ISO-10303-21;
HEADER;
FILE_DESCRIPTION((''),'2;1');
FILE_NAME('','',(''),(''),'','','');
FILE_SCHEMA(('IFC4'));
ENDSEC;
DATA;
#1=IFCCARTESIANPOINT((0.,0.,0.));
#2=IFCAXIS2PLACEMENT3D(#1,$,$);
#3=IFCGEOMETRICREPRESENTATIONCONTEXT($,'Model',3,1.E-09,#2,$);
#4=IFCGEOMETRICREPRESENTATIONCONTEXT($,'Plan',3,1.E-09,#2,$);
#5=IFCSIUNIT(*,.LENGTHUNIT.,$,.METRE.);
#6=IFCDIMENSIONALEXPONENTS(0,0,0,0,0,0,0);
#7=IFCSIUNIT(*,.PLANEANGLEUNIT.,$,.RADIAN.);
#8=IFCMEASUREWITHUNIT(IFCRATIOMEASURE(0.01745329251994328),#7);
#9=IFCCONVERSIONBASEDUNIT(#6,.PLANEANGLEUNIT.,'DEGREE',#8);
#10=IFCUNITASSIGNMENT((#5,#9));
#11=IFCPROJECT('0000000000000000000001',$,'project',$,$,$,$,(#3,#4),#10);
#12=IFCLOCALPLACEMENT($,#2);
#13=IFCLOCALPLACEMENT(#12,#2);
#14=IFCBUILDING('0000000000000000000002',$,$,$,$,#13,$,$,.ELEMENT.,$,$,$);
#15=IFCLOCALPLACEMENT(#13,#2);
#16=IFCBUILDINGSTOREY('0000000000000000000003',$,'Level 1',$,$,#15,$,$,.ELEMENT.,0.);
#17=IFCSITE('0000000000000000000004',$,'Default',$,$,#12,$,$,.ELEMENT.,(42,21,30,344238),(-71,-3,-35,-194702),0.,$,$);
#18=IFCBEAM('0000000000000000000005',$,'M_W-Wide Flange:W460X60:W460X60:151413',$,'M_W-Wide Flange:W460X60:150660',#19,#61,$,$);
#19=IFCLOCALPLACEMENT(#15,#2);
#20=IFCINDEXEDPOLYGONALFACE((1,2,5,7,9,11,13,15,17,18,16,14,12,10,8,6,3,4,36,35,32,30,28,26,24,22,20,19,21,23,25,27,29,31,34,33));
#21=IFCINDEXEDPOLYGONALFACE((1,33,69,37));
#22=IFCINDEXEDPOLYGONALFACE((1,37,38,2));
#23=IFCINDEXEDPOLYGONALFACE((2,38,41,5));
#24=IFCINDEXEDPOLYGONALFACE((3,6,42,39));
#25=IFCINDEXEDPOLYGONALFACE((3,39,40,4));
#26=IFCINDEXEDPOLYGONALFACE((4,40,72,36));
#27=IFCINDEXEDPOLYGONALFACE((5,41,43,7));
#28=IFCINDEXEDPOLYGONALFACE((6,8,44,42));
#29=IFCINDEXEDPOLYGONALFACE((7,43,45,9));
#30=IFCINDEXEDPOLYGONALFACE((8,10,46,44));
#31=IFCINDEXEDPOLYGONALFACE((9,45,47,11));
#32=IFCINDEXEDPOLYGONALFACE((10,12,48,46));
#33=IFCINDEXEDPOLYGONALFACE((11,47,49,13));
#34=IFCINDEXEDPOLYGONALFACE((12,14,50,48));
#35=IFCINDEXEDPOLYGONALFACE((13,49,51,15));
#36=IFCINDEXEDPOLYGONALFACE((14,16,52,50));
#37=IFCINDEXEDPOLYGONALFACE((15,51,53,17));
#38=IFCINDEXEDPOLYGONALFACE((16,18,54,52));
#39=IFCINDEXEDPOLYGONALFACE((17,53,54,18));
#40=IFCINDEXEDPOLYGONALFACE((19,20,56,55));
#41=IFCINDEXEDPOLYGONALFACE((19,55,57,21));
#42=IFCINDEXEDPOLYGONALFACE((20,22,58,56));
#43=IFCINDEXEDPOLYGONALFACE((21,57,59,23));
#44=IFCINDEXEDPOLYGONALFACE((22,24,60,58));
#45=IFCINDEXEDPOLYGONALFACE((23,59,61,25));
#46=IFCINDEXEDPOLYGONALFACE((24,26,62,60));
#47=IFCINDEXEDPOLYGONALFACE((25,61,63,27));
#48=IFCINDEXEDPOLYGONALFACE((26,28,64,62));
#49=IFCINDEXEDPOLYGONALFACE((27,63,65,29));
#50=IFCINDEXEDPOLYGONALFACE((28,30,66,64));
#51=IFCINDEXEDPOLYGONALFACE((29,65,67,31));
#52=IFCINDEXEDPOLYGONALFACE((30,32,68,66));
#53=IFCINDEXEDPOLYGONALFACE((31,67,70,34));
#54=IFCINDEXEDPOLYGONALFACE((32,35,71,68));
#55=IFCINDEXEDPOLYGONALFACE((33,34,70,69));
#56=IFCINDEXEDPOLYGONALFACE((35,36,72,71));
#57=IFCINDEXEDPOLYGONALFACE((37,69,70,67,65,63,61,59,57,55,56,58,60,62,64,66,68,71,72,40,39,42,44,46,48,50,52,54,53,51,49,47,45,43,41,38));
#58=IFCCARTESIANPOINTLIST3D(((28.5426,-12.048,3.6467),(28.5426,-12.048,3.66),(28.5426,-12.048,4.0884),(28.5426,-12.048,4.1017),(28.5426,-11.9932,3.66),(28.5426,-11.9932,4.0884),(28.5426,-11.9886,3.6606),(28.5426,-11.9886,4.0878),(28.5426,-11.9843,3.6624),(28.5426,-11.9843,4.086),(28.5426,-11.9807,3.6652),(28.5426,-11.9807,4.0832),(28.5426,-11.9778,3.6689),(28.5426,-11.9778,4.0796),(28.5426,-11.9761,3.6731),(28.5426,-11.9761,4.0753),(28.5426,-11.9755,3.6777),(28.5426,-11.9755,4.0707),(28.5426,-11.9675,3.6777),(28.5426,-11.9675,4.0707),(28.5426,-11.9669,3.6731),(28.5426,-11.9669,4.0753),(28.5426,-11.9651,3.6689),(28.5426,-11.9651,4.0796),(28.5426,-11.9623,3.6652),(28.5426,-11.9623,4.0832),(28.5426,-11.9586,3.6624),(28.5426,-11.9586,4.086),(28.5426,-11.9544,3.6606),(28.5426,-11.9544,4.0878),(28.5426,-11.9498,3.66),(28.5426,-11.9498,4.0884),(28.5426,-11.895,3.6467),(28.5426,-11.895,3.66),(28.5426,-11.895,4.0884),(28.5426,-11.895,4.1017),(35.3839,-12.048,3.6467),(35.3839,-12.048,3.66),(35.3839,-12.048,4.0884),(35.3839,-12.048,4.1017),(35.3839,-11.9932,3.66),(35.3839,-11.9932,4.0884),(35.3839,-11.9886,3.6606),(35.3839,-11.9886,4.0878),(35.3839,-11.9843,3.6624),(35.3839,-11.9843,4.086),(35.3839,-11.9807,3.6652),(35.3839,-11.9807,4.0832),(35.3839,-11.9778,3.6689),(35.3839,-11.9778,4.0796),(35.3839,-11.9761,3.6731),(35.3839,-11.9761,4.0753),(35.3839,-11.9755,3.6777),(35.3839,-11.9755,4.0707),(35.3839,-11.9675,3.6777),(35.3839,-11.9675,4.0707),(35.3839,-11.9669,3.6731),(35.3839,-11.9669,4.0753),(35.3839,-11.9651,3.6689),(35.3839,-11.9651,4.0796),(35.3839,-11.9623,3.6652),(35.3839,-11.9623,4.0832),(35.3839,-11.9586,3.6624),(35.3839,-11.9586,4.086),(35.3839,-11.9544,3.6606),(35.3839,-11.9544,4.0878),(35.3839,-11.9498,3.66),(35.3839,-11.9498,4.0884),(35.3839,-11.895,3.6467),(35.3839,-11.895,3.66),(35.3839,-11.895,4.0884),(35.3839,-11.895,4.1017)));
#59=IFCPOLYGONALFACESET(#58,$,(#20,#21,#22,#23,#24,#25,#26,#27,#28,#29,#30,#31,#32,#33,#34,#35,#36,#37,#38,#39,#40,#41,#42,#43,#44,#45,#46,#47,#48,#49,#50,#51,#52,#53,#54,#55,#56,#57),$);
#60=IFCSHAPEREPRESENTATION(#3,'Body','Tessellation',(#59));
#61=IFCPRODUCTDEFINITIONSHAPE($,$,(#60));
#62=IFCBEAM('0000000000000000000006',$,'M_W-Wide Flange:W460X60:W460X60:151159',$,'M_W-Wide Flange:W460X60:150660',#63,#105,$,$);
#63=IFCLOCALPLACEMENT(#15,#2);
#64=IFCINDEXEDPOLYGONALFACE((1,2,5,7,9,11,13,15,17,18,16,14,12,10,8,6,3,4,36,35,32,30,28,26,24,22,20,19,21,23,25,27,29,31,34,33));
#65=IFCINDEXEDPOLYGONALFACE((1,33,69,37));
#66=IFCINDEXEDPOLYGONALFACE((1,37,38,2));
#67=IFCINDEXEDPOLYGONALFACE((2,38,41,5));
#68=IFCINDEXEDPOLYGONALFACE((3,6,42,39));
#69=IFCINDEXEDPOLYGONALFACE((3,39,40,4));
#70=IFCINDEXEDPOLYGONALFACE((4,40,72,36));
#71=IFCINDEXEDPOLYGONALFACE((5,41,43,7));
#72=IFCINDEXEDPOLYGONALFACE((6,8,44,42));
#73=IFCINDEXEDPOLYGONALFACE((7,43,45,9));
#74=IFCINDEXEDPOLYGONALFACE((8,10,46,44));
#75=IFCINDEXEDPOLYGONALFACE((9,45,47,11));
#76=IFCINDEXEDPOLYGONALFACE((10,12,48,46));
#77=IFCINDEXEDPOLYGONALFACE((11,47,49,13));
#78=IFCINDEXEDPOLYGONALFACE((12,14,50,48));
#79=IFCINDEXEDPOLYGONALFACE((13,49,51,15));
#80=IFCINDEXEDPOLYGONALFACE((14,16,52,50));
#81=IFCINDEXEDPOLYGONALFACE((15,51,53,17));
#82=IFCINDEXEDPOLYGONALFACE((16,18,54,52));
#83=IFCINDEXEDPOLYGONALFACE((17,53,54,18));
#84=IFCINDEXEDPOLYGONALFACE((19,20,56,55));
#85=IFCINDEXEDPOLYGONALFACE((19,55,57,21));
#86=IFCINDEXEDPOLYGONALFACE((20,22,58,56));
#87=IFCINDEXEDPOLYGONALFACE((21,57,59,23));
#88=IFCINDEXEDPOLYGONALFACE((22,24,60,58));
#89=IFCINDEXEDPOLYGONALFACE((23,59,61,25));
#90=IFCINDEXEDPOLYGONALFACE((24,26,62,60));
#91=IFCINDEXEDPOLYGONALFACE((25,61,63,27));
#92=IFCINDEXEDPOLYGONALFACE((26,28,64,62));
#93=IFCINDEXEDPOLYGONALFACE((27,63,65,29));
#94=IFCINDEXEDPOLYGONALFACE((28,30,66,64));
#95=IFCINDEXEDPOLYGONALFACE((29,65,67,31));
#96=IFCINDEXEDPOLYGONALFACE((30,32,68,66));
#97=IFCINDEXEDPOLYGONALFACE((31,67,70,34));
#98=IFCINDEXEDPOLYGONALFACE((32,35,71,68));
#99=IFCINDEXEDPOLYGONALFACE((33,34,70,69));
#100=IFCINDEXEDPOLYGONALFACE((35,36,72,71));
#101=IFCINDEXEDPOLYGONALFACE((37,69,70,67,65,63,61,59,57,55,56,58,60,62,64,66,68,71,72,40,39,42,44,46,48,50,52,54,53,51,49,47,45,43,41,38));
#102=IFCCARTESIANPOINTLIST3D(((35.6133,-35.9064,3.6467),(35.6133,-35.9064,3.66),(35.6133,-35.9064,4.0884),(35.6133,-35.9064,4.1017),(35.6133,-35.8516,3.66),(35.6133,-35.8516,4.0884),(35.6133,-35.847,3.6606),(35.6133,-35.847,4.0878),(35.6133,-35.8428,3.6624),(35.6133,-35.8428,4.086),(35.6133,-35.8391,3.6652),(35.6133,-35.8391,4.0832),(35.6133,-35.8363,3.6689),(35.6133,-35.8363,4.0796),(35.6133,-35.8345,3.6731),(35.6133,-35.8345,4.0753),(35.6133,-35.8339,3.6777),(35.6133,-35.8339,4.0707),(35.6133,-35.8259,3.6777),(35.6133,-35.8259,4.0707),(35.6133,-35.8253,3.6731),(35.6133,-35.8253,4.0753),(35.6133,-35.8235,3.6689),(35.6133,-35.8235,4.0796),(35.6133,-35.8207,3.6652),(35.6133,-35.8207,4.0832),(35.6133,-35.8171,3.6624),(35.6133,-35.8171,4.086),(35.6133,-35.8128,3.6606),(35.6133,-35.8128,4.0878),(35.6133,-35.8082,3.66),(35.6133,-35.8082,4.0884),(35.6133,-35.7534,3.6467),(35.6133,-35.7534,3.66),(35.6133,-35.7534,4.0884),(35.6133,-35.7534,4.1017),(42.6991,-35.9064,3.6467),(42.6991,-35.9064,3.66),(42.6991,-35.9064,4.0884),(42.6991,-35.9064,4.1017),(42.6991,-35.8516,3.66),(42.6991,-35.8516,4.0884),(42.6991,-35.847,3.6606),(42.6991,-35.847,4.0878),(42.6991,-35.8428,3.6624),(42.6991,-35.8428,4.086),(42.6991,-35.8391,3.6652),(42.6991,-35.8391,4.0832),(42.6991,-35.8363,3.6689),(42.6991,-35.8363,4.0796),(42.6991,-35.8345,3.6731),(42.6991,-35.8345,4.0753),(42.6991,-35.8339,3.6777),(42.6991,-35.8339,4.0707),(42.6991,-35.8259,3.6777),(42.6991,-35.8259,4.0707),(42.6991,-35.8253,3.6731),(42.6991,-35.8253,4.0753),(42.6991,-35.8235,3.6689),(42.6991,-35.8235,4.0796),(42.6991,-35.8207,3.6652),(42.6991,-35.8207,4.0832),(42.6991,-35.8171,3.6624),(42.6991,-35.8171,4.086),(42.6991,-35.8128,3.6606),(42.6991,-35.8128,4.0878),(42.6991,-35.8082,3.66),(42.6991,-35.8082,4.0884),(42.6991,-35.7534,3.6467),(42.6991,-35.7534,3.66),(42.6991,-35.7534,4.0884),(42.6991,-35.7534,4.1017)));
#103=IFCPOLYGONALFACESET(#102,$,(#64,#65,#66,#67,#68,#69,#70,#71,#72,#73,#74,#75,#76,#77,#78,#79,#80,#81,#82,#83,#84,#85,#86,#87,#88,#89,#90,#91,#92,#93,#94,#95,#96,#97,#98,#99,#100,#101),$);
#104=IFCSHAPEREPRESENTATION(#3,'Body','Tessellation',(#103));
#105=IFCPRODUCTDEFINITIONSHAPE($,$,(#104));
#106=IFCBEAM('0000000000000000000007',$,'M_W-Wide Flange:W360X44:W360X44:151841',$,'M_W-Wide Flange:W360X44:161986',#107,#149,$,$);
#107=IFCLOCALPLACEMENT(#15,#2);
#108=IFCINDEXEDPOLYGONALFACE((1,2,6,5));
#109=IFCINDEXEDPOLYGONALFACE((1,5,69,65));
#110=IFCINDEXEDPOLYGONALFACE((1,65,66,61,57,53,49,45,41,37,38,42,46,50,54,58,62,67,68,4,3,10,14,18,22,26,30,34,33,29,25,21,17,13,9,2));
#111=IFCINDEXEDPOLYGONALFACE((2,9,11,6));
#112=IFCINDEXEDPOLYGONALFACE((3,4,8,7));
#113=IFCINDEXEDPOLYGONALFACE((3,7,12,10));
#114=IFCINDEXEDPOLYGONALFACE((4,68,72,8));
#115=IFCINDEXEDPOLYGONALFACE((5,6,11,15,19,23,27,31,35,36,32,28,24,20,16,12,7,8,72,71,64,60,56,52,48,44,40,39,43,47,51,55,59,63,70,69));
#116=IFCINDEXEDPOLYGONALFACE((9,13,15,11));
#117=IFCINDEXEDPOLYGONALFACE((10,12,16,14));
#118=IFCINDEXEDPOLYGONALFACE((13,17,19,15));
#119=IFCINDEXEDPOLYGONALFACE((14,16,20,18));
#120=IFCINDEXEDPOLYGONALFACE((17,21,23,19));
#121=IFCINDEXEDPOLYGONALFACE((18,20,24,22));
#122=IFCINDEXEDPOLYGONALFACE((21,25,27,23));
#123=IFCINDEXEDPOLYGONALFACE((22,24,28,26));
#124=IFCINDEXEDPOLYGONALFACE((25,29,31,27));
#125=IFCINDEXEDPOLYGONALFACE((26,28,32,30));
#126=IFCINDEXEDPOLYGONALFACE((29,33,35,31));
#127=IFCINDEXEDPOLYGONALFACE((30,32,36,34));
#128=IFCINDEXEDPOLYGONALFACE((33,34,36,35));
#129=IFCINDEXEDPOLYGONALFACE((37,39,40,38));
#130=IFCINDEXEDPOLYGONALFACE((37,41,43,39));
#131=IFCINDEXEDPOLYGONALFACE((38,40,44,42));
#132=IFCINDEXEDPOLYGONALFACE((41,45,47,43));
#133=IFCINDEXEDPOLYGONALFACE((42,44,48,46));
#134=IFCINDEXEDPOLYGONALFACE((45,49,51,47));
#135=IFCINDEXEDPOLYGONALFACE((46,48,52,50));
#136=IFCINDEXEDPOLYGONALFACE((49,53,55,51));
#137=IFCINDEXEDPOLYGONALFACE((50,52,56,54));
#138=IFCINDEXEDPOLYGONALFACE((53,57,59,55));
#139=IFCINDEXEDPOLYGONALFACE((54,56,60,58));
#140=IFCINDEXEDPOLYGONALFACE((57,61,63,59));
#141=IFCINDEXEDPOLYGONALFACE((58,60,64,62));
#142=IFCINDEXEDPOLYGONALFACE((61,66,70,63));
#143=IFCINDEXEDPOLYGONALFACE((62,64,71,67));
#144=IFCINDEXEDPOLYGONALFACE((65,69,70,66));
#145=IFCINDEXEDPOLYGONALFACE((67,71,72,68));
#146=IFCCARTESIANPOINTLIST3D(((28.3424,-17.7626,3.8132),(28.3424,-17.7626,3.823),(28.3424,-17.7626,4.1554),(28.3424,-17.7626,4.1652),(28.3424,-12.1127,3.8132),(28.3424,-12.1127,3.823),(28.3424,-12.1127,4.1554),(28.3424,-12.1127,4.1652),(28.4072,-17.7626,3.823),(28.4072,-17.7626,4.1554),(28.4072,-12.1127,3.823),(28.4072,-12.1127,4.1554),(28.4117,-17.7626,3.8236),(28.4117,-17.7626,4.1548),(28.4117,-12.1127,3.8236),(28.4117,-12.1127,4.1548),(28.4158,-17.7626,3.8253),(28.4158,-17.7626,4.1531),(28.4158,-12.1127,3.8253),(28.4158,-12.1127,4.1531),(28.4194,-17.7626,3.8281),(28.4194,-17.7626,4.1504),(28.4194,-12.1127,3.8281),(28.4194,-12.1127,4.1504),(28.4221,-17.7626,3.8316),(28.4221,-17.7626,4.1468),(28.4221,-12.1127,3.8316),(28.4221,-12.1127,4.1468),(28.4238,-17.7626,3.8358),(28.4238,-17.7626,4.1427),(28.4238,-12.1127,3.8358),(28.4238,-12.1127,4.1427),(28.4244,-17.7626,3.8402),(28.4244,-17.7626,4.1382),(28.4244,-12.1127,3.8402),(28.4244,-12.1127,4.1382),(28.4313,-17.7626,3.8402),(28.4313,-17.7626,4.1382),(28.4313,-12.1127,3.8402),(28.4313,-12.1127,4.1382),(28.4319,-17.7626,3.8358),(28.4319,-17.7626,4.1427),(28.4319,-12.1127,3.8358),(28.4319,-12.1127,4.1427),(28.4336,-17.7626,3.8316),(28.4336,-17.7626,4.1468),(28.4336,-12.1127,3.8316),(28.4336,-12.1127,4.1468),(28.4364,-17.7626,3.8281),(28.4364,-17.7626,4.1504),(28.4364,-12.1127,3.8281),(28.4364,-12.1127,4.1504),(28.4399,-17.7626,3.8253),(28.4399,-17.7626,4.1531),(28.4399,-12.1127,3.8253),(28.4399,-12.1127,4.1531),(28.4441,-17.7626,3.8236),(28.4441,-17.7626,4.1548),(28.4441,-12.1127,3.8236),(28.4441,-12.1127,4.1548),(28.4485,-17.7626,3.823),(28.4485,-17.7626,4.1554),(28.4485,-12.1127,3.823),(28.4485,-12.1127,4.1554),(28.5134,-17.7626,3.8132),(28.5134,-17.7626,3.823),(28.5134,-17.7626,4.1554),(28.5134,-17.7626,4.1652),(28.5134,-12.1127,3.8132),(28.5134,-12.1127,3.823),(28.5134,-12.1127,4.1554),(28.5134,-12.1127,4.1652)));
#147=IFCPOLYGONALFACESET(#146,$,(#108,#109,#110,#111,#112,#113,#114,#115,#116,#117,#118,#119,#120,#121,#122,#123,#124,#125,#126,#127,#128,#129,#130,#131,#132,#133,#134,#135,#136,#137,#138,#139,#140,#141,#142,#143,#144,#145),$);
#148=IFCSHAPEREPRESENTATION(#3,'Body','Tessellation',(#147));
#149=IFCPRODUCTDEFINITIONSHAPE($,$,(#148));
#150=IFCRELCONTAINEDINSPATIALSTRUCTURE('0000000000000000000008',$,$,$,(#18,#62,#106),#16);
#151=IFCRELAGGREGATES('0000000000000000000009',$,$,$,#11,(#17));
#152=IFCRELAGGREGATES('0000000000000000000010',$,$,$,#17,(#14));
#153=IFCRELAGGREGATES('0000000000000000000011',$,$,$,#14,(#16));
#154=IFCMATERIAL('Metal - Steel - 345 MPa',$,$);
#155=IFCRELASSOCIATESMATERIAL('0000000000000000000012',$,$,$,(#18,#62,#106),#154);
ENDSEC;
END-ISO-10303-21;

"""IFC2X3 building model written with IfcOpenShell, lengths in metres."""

from ifc_helpers import new_model, entity, si_unit, converted_unit, frame, frame_2d, origin, place, context, project, spatial, polyline, circle_curve, parameter, trimmed, segment, composite_curve, outline, extrude, material, element, save


model = new_model("IFC2X3")

# Units and contexts
model_context = context("Model", 3, precision=1e-09, world=origin())
plan_context = context("Plan", 3, precision=1e-09, world=origin())
ifc_project = project(units=[si_unit("LENGTHUNIT", "METRE"), converted_unit("PLANEANGLEUNIT", "DEGREE", entity("IfcRatioMeasure", 0.01745329251994328), si_unit("PLANEANGLEUNIT", "RADIAN"), dimensions=[0, 0, 0, 0, 0, 0, 0])], contexts=[model_context, plan_context])

# Site, building, storey
site_placement = place(None, origin())
site = spatial("IfcSite", under=ifc_project, at=site_placement, Name="Default", CompositionType="ELEMENT", RefLatitude=(42, 21, 30, 344238), RefLongitude=(-71, -3, -35, -194702), RefElevation=0.0)
building_placement = place(site_placement, origin())
building = spatial("IfcBuilding", under=site, at=building_placement, CompositionType="ELEMENT")
storey_placement = place(building_placement, origin())
storey = spatial("IfcBuildingStorey", under=building, at=storey_placement, Name="Level 1", CompositionType="ELEMENT", Elevation=0.0)

# Beams
ifc_material = material(Name="Metal - Steel - 345 MPa")
beam_1_placement = place(storey_placement, frame((28.4279, -11.9715, 4.2672), z_axis=(0.0, 0.0, 1.0), x_axis=(0.0, -1.0, 0.0)))
element("IfcBeam", 1, at=beam_1_placement, inside=storey, material=ifc_material, Name="M_W-Wide Flange:W460X60:W460X60:151413", ObjectType="M_W-Wide Flange:W460X60:150660", context=model_context, shape_type="SweptSolid", body=[
    extrude(outline(composite_curve([segment(polyline([(-0.0765, -0.2142), (-0.0765, -0.2275)]), True, "CONTINUOUS"), segment(polyline([(-0.0765, -0.2275), (0.0765, -0.2275)]), True, "CONTINUOUS"), segment(polyline([(0.0765, -0.2275), (0.0765, -0.2142)]), True, "CONTINUOUS"), segment(polyline([(0.0765, -0.2142), (0.0217, -0.2142)]), True, "CONTINUOUS"), segment(trimmed(circle_curve(frame_2d((0.0217, -0.1965), x_axis=(0.0, -1.0)), 0.0177), [parameter(270.0)], [parameter(360.0)], True, "PARAMETER"), False, "CONTINUOUS"), segment(polyline([(0.004, -0.1965), (0.004, 0.1965)]), True, "CONTINUOUS"), segment(trimmed(circle_curve(frame_2d((0.0217, 0.1965), x_axis=(-1.0, 0.0)), 0.0177), [parameter(270.0)], [parameter(360.0)], True, "PARAMETER"), False, "CONTINUOUS"), segment(polyline([(0.0217, 0.2142), (0.0765, 0.2142)]), True, "CONTINUOUS"), segment(polyline([(0.0765, 0.2142), (0.0765, 0.2275)]), True, "CONTINUOUS"), segment(polyline([(0.0765, 0.2275), (-0.0765, 0.2275)]), True, "CONTINUOUS"), segment(polyline([(-0.0765, 0.2275), (-0.0765, 0.2142)]), True, "CONTINUOUS"), segment(polyline([(-0.0765, 0.2142), (-0.0217, 0.2142)]), True, "CONTINUOUS"), segment(trimmed(circle_curve(frame_2d((-0.0217, 0.1965), x_axis=(0.0, 1.0)), 0.0177), [parameter(270.0)], [parameter(360.0)], True, "PARAMETER"), False, "CONTINUOUS"), segment(polyline([(-0.004, 0.1965), (-0.004, -0.1965)]), True, "CONTINUOUS"), segment(trimmed(circle_curve(frame_2d((-0.0217, -0.1965), x_axis=(1.0, 0.0)), 0.0177), [parameter(270.0)], [parameter(0.0)], True, "PARAMETER"), False, "CONTINUOUS"), segment(polyline([(-0.0217, -0.2142), (-0.0765, -0.2142)]), True, "CONTINUOUS")], self_intersect=False)), frame((0.0, 0.1147, -0.393), z_axis=(0.0, -1.0, 0.0), x_axis=(1.0, 0.0, 0.0)), (0.0, 0.0, -1.0), 6.8414),
])
beam_2_placement = place(storey_placement, frame((42.8138, -35.8299, 4.2672), z_axis=(0.0, 0.0, 1.0), x_axis=(0.0, 1.0, 0.0)))
element("IfcBeam", 2, at=beam_2_placement, inside=storey, material=ifc_material, Name="M_W-Wide Flange:W460X60:W460X60:151159", ObjectType="M_W-Wide Flange:W460X60:150660", context=model_context, shape_type="SweptSolid", body=[
    extrude(outline(composite_curve([segment(polyline([(0.2142, -0.0765), (0.2275, -0.0765)]), True, "CONTINUOUS"), segment(polyline([(0.2275, -0.0765), (0.2275, 0.0765)]), True, "CONTINUOUS"), segment(polyline([(0.2275, 0.0765), (0.2142, 0.0765)]), True, "CONTINUOUS"), segment(polyline([(0.2142, 0.0765), (0.2142, 0.0217)]), True, "CONTINUOUS"), segment(trimmed(circle_curve(frame_2d((0.1965, 0.0217), x_axis=(1.0, 0.0)), 0.0177), [parameter(270.0)], [parameter(360.0)], True, "PARAMETER"), False, "CONTINUOUS"), segment(polyline([(0.1965, 0.004), (-0.1965, 0.004)]), True, "CONTINUOUS"), segment(trimmed(circle_curve(frame_2d((-0.1965, 0.0217), x_axis=(0.0, -1.0)), 0.0177), [parameter(270.0)], [parameter(360.0)], True, "PARAMETER"), False, "CONTINUOUS"), segment(polyline([(-0.2142, 0.0217), (-0.2142, 0.0765)]), True, "CONTINUOUS"), segment(polyline([(-0.2142, 0.0765), (-0.2275, 0.0765)]), True, "CONTINUOUS"), segment(polyline([(-0.2275, 0.0765), (-0.2275, -0.0765)]), True, "CONTINUOUS"), segment(polyline([(-0.2275, -0.0765), (-0.2142, -0.0765)]), True, "CONTINUOUS"), segment(polyline([(-0.2142, -0.0765), (-0.2142, -0.0217)]), True, "CONTINUOUS"), segment(trimmed(circle_curve(frame_2d((-0.1965, -0.0217), x_axis=(-1.0, 0.0)), 0.0177), [parameter(270.0)], [parameter(360.0)], True, "PARAMETER"), False, "CONTINUOUS"), segment(polyline([(-0.1965, -0.004), (0.1965, -0.004)]), True, "CONTINUOUS"), segment(trimmed(circle_curve(frame_2d((0.1965, -0.0217), x_axis=(0.0, 1.0)), 0.0177), [parameter(270.0)], [parameter(0.0)], True, "PARAMETER"), False, "CONTINUOUS"), segment(polyline([(0.2142, -0.0217), (0.2142, -0.0765)]), True, "CONTINUOUS")], self_intersect=False)), frame((0.0, 7.2005, -0.393), z_axis=(0.0, -1.0, 0.0), x_axis=(0.0, 0.0, -1.0)), (0.0, 0.0, 1.0), 7.0858),
])
beam_3_placement = place(storey_placement, frame((28.4279, -11.9715, 4.2672), z_axis=(0.0, 0.0, 1.0), x_axis=(-1.0, 0.0, 0.0)))
element("IfcBeam", 3, at=beam_3_placement, inside=storey, material=ifc_material, Name="M_W-Wide Flange:W360X44:W360X44:151841", ObjectType="M_W-Wide Flange:W360X44:161986", context=model_context, shape_type="SweptSolid", body=[
    extrude(outline(composite_curve([segment(polyline([(0.1662, -0.0855), (0.176, -0.0855)]), True, "CONTINUOUS"), segment(polyline([(0.176, -0.0855), (0.176, 0.0855)]), True, "CONTINUOUS"), segment(polyline([(0.176, 0.0855), (0.1662, 0.0855)]), True, "CONTINUOUS"), segment(polyline([(0.1662, 0.0855), (0.1662, 0.0206)]), True, "CONTINUOUS"), segment(trimmed(circle_curve(frame_2d((0.149, 0.0206), x_axis=(0.0, 1.0)), 0.0172), [parameter(180.0)], [parameter(270.0)], True, "PARAMETER"), False, "CONTINUOUS"), segment(polyline([(0.149, 0.0034), (-0.149, 0.0034)]), True, "CONTINUOUS"), segment(trimmed(circle_curve(frame_2d((-0.149, 0.0206), x_axis=(0.0, 1.0)), 0.0172), [parameter(90.0)], [parameter(180.0)], True, "PARAMETER"), False, "CONTINUOUS"), segment(polyline([(-0.1662, 0.0206), (-0.1662, 0.0855)]), True, "CONTINUOUS"), segment(polyline([(-0.1662, 0.0855), (-0.176, 0.0855)]), True, "CONTINUOUS"), segment(polyline([(-0.176, 0.0855), (-0.176, -0.0855)]), True, "CONTINUOUS"), segment(polyline([(-0.176, -0.0855), (-0.1662, -0.0855)]), True, "CONTINUOUS"), segment(polyline([(-0.1662, -0.0855), (-0.1662, -0.0206)]), True, "CONTINUOUS"), segment(trimmed(circle_curve(frame_2d((-0.149, -0.0206), x_axis=(0.0, 1.0)), 0.0172), [parameter(360.0)], [parameter(90.0)], True, "PARAMETER"), False, "CONTINUOUS"), segment(polyline([(-0.149, -0.0034), (0.149, -0.0034)]), True, "CONTINUOUS"), segment(trimmed(circle_curve(frame_2d((0.149, -0.0206), x_axis=(0.0, 1.0)), 0.0172), [parameter(270.0)], [parameter(0.0)], True, "PARAMETER"), False, "CONTINUOUS"), segment(polyline([(0.1662, -0.0206), (0.1662, -0.0855)]), True, "CONTINUOUS")], self_intersect=False)), frame((0.0, 5.7912, -0.278), z_axis=(0.0, -1.0, 0.0), x_axis=(0.0, 0.0, -1.0)), (0.0, 0.0, 1.0), 5.65),
])

save(model, "model.ifc")
